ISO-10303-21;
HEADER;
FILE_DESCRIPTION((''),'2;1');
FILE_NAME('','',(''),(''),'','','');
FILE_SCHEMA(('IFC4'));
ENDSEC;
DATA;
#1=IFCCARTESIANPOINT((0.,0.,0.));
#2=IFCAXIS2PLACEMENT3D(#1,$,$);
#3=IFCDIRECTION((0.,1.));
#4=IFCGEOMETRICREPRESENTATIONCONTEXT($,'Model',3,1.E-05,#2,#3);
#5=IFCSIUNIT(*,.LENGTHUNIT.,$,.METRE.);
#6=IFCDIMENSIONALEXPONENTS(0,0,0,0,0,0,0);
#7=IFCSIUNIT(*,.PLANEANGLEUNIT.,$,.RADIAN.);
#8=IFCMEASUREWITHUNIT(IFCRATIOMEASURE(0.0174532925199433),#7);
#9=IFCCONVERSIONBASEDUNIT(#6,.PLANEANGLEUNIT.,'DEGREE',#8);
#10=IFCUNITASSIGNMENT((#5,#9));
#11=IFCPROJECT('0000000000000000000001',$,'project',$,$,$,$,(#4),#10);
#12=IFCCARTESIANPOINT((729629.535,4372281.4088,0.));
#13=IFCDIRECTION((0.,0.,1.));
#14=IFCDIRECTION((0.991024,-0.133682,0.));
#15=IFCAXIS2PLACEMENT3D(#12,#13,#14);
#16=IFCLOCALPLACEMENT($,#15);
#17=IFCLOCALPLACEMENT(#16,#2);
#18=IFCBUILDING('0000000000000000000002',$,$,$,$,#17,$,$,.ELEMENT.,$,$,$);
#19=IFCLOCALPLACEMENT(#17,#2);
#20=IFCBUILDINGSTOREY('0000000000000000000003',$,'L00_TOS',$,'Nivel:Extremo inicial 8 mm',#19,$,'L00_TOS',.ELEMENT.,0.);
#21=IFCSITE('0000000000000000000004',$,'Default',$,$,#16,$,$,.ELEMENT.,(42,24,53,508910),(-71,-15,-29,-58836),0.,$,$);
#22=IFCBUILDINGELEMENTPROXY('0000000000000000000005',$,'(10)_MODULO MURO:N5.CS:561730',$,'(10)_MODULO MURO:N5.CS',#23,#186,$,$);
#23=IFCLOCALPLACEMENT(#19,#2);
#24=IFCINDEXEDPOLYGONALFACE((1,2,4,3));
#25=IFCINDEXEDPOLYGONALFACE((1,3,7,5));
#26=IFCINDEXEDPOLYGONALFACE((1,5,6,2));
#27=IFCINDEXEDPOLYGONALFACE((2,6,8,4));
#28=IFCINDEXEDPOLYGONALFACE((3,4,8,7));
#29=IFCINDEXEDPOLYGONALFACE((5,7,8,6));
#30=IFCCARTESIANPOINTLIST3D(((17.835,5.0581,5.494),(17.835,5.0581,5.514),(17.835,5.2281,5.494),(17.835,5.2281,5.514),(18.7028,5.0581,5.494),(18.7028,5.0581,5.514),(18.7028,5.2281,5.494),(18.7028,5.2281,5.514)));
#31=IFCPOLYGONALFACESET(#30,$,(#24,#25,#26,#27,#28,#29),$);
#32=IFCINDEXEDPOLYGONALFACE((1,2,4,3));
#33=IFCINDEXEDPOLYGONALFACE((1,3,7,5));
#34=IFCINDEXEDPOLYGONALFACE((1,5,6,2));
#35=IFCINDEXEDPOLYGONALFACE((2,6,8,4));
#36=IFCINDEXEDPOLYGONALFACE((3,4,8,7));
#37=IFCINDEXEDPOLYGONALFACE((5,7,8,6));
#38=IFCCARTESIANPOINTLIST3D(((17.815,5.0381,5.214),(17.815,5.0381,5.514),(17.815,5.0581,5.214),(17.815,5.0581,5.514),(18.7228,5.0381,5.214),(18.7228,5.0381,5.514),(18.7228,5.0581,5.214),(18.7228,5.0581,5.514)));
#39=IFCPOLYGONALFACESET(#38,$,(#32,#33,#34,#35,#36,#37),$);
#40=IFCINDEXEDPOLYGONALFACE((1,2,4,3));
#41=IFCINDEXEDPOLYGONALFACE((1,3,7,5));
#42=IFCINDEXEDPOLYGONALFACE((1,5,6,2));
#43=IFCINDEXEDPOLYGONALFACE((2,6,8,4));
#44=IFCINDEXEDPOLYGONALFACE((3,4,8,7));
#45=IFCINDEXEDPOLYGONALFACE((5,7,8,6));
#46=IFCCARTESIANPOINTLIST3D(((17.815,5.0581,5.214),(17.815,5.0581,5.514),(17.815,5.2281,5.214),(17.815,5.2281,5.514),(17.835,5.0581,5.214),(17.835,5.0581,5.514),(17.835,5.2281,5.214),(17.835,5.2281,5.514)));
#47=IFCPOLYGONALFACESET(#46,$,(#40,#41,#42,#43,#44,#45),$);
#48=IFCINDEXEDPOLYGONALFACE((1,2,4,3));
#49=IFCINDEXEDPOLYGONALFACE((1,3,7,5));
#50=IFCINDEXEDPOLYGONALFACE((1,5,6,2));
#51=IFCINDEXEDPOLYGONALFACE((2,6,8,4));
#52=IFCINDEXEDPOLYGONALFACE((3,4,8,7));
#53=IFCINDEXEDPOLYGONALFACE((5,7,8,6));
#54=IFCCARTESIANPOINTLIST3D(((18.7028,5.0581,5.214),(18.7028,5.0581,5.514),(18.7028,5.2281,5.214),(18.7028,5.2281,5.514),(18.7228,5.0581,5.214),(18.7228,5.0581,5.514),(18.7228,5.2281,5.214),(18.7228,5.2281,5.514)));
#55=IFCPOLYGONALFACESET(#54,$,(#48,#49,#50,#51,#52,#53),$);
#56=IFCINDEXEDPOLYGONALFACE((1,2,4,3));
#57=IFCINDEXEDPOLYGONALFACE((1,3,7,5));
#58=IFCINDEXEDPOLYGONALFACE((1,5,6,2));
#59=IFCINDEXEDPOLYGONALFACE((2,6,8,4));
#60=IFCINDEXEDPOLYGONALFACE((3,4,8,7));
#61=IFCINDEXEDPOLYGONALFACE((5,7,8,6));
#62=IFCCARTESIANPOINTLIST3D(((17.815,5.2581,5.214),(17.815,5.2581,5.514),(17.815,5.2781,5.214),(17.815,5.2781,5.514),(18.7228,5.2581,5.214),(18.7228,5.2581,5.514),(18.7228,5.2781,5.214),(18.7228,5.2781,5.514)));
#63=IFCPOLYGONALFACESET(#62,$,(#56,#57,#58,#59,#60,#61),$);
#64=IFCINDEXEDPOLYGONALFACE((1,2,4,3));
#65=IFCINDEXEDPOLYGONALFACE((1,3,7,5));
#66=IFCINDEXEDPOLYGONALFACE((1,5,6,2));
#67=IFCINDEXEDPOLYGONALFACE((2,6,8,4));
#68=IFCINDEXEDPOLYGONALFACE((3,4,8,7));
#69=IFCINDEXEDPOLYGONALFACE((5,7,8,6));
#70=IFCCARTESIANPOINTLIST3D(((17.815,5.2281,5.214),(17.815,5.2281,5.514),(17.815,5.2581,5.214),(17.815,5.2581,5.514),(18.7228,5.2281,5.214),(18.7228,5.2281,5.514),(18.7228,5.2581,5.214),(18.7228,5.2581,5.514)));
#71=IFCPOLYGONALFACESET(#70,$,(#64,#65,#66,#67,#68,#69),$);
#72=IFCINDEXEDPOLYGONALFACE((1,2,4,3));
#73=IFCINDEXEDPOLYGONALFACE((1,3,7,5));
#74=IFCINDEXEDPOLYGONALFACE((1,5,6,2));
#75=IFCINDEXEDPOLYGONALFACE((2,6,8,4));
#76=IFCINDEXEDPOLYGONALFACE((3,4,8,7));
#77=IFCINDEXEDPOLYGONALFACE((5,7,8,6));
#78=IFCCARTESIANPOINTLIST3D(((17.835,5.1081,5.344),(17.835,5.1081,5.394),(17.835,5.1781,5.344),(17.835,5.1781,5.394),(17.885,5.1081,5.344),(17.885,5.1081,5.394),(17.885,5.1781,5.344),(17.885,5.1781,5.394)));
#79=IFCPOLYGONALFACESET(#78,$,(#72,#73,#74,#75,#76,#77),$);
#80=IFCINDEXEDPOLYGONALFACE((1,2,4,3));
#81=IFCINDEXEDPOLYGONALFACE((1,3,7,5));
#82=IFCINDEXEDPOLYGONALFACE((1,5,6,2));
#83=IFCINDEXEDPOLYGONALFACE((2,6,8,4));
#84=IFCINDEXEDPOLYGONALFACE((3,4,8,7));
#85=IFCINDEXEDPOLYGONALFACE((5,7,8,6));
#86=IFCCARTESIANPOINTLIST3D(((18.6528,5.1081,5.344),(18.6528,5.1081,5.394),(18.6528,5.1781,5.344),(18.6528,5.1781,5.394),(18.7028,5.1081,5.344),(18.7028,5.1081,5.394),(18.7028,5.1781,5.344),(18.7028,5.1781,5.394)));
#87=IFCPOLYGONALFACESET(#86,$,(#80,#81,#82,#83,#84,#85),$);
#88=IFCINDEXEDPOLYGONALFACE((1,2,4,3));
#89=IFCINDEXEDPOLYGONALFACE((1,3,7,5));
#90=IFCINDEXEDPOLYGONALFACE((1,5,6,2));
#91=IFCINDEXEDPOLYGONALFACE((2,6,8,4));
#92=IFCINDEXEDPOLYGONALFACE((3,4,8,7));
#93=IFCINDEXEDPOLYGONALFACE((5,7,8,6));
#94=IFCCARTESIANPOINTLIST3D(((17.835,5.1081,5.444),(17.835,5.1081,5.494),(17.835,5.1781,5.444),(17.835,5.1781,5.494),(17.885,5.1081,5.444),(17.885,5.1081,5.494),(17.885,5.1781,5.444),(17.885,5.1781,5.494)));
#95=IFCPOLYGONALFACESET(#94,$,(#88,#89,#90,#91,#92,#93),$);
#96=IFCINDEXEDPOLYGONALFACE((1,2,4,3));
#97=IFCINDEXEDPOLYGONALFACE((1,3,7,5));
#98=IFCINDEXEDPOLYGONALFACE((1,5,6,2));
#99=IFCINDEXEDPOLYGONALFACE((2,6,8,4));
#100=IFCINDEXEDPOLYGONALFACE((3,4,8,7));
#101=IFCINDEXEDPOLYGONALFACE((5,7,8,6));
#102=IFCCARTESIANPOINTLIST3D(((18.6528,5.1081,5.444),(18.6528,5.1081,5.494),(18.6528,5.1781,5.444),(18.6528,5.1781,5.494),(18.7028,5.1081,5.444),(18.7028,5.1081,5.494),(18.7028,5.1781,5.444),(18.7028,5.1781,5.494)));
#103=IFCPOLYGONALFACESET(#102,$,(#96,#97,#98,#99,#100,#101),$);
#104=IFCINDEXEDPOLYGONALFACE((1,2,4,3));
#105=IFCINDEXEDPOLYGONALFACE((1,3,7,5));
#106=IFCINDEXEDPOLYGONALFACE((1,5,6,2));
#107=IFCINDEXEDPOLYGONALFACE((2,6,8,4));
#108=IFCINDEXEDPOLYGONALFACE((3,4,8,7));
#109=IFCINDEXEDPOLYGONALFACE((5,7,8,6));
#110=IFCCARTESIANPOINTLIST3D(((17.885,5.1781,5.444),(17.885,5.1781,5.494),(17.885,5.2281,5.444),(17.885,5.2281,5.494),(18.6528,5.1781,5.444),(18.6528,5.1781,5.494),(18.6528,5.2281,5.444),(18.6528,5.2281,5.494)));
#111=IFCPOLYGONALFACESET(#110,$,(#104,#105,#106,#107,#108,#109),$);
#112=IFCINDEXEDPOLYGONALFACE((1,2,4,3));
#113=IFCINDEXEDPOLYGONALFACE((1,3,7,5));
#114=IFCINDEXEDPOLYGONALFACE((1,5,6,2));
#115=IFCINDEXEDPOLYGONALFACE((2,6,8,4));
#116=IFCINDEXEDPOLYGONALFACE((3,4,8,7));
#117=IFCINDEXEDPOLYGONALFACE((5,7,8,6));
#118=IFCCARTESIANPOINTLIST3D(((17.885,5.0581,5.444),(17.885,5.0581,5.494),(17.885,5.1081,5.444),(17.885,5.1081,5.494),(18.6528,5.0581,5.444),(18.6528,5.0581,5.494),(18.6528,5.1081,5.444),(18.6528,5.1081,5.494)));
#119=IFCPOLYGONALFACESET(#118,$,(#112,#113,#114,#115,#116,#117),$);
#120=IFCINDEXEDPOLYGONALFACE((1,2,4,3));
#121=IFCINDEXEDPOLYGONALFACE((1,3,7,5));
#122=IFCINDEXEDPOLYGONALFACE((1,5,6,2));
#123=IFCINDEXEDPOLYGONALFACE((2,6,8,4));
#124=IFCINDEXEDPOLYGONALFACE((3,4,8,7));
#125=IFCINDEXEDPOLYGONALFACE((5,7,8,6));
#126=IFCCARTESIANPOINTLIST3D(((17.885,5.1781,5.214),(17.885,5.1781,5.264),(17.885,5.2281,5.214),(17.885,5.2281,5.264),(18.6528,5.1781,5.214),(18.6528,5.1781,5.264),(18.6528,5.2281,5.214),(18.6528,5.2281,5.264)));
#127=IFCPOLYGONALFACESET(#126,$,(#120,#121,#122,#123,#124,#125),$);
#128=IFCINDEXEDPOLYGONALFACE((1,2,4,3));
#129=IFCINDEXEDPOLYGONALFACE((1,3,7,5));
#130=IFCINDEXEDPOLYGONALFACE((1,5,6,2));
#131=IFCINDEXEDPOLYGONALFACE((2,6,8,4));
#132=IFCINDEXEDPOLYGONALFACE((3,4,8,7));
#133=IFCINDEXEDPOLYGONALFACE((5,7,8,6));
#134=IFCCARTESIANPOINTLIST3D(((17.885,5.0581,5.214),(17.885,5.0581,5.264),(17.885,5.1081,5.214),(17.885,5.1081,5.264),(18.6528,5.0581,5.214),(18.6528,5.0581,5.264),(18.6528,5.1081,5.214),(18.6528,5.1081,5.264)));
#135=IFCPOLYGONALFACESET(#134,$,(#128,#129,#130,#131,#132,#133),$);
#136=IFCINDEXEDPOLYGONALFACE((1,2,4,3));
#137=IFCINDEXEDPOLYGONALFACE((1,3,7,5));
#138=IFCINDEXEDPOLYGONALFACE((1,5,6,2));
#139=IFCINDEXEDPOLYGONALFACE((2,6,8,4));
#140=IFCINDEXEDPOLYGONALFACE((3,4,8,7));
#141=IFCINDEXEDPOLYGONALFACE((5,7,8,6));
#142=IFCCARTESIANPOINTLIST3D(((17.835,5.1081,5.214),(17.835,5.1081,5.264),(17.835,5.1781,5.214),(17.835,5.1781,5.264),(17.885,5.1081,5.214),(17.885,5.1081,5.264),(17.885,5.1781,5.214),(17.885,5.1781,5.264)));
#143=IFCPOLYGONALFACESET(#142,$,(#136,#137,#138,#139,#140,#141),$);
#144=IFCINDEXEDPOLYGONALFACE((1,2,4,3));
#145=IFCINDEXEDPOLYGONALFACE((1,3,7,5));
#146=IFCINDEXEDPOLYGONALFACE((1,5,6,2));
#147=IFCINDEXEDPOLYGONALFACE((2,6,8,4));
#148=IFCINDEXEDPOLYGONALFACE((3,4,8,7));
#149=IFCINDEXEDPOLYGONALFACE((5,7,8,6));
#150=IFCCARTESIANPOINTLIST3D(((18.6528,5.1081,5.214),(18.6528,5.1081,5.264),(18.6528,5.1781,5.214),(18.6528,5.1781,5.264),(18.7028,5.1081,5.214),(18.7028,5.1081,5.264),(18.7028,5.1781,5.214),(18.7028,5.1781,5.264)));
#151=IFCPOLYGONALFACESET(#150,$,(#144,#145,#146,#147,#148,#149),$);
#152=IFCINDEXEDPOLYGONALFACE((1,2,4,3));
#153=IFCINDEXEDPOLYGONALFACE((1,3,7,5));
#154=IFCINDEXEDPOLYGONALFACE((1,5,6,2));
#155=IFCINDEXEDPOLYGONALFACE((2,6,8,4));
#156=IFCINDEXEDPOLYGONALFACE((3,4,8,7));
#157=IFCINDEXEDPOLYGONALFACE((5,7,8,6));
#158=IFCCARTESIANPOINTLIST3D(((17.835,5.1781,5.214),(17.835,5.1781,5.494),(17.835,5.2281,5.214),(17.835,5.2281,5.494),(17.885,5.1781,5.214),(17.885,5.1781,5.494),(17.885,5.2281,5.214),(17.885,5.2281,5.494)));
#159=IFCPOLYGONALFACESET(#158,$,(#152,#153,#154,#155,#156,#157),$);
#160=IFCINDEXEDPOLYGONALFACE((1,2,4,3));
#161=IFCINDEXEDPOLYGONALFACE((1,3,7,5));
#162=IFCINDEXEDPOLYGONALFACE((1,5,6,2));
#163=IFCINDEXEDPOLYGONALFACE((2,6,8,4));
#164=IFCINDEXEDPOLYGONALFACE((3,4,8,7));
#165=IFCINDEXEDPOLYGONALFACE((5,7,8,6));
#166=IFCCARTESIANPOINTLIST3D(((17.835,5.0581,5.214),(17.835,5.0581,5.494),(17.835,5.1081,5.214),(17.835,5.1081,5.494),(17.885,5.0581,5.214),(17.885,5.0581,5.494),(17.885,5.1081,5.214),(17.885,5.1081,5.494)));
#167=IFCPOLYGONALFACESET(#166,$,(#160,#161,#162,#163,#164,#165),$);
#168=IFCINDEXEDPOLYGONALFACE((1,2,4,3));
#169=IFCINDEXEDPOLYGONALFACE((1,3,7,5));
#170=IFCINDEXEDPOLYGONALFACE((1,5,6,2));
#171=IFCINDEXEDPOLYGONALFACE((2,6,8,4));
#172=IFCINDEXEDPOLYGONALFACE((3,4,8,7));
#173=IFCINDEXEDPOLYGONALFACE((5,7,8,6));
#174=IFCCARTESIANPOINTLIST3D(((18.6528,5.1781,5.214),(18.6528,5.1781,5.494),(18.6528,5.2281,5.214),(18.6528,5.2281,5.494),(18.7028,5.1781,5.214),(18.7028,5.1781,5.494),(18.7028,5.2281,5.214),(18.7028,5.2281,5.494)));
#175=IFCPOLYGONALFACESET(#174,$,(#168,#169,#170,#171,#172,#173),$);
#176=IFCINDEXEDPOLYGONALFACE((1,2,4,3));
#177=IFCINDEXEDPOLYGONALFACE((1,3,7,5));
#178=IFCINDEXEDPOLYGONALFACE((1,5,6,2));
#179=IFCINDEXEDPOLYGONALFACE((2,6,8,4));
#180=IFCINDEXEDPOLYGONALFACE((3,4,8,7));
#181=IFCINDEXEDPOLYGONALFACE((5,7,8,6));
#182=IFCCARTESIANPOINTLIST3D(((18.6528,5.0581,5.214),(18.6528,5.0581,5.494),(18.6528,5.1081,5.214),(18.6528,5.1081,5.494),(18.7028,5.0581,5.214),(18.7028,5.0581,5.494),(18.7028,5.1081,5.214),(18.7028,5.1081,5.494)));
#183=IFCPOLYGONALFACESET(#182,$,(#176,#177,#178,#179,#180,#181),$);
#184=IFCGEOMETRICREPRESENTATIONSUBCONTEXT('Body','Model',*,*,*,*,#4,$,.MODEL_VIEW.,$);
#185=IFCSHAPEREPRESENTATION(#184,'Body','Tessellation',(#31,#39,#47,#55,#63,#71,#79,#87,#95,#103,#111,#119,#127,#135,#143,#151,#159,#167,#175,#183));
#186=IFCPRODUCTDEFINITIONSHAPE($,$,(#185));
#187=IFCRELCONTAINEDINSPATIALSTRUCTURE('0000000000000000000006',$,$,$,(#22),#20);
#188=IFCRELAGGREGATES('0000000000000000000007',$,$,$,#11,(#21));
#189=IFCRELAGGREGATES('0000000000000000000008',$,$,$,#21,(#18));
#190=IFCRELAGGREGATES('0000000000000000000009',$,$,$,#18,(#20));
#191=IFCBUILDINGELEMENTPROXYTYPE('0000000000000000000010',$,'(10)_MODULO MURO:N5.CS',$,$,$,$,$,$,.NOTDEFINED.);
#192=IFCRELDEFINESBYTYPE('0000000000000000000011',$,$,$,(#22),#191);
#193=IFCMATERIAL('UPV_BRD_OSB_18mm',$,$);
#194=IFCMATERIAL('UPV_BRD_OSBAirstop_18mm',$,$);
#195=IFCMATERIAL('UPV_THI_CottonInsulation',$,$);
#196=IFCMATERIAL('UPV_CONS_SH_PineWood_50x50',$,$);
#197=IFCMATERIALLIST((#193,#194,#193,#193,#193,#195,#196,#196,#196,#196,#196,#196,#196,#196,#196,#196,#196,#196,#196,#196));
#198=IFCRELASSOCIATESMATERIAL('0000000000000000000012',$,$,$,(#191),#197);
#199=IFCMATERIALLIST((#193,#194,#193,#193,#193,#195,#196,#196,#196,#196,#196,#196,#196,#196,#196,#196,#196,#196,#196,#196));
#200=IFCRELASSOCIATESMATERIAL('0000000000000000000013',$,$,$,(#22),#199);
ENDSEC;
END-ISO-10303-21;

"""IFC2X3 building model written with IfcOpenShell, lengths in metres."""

from ifc_helpers import new_model, entity, si_unit, converted_unit, direction, frame, frame_2d, origin, origin_2d_with_axis, place, context, subcontext, project, spatial, rectangle, extrude, source, transform, mapped, material, material_list, type_object, type_shapes, element, save


model = new_model("IFC2X3")

# Units and contexts
model_context = context("Model", 3, precision=1e-05, world=origin(), true_north=direction((0.0, 1.0)))
body_context = subcontext(model_context, "Body", "Model", "MODEL_VIEW")
ifc_project = project(units=[si_unit("LENGTHUNIT", "METRE"), converted_unit("PLANEANGLEUNIT", "DEGREE", entity("IfcRatioMeasure", 0.0174532925199433), si_unit("PLANEANGLEUNIT", "RADIAN"), dimensions=[0, 0, 0, 0, 0, 0, 0])], contexts=[model_context])

# Site, building, storey
site_placement = place(None, frame((729629.535, 4372281.4088, 0.0), z_axis=(0.0, 0.0, 1.0), x_axis=(0.991024, -0.133682, 0.0)))
site = spatial("IfcSite", under=ifc_project, at=site_placement, Name="Default", CompositionType="ELEMENT", RefLatitude=(42, 24, 53, 508910), RefLongitude=(-71, -15, -29, -58836), RefElevation=0.0)
building_placement = place(site_placement, origin())
building = spatial("IfcBuilding", under=site, at=building_placement, CompositionType="ELEMENT")
storey_placement = place(building_placement, origin())
storey = spatial("IfcBuildingStorey", under=building, at=storey_placement, Name="L00_TOS", ObjectType="Nivel:Extremo inicial 8 mm", LongName="L00_TOS", CompositionType="ELEMENT", Elevation=0.0)

# Building element proxy
ifc_material_1 = material(Name="UPV_BRD_OSBAirstop_18mm")
ifc_material_2 = material(Name="UPV_BRD_OSB_18mm")
ifc_material_3 = material(Name="UPV_THI_CottonInsulation")
ifc_material_4 = material(Name="UPV_CONS_SH_PineWood_50x50")
ifc_material_list_1 = material_list([ifc_material_2, ifc_material_1, ifc_material_2, ifc_material_2, ifc_material_2, ifc_material_3, ifc_material_4, ifc_material_4, ifc_material_4, ifc_material_4, ifc_material_4, ifc_material_4, ifc_material_4, ifc_material_4, ifc_material_4, ifc_material_4, ifc_material_4, ifc_material_4, ifc_material_4, ifc_material_4])
ifc_material_list_2 = material_list([ifc_material_2, ifc_material_1, ifc_material_2, ifc_material_2, ifc_material_2, ifc_material_3, ifc_material_4, ifc_material_4, ifc_material_4, ifc_material_4, ifc_material_4, ifc_material_4, ifc_material_4, ifc_material_4, ifc_material_4, ifc_material_4, ifc_material_4, ifc_material_4, ifc_material_4, ifc_material_4])
building_element_proxy_type_1 = type_object("IfcBuildingElementProxyType", Name="(10)_MODULO MURO:N5.CS", PredefinedType="NOTDEFINED", material=ifc_material_list_2)
shared_shape_1 = source(origin(), body_context, "Body", "SweptSolid", [
    extrude(rectangle(XDim=0.8678, YDim=0.17, at=origin_2d_with_axis()), frame((0.0, 0.0, 0.28), z_axis=(0.0, 0.0, 1.0), x_axis=(-1.0, 0.0, 0.0)), (0.0, 0.0, 1.0), 0.02),
    extrude(rectangle(XDim=0.9078, YDim=0.02, at=origin_2d_with_axis()), frame((0.0, -0.095, 0.0)), (0.0, 0.0, 1.0), 0.3),
    extrude(rectangle(XDim=0.17, YDim=0.02, at=frame_2d((0.0, 0.0), x_axis=(1.0, 0.0))), frame((-0.4439, 0.0, 0.0), z_axis=(0.0, 0.0, 1.0), x_axis=(0.0, -1.0, 0.0)), (0.0, 0.0, 1.0), 0.3),
    extrude(rectangle(XDim=0.17, YDim=0.02, at=origin_2d_with_axis()), frame((0.4439, 0.0, 0.0), z_axis=(0.0, 0.0, 1.0), x_axis=(0.0, -1.0, 0.0)), (0.0, 0.0, 1.0), 0.3),
    extrude(rectangle(XDim=0.9078, YDim=0.02, at=origin_2d_with_axis()), frame((0.0, 0.125, 0.0), z_axis=(0.0, 0.0, 1.0), x_axis=(-1.0, 0.0, 0.0)), (0.0, 0.0, 1.0), 0.3),
    extrude(rectangle(XDim=0.9078, YDim=0.03, at=frame_2d((0.0, 0.0), x_axis=(1.0, 0.0))), frame((0.0, 0.1, 0.0), z_axis=(0.0, 0.0, 1.0), x_axis=(-1.0, 0.0, 0.0)), (0.0, 0.0, 1.0), 0.3),
    extrude(rectangle(XDim=0.07, YDim=0.05, at=origin_2d_with_axis()), frame((-0.4089, 0.0, 0.13), z_axis=(0.0, 0.0, 1.0), x_axis=(0.0, 1.0, 0.0)), (0.0, 0.0, 1.0), 0.05),
    extrude(rectangle(XDim=0.07, YDim=0.05, at=origin_2d_with_axis()), frame((0.4089, 0.0, 0.13), z_axis=(0.0, 0.0, 1.0), x_axis=(0.0, 1.0, 0.0)), (0.0, 0.0, 1.0), 0.05),
    extrude(rectangle(XDim=0.07, YDim=0.05, at=origin_2d_with_axis()), frame((-0.4089, 0.0, 0.23), z_axis=(0.0, 0.0, 1.0), x_axis=(0.0, -1.0, 0.0)), (0.0, 0.0, 1.0), 0.05),
    extrude(rectangle(XDim=0.07, YDim=0.05, at=frame_2d((0.0, 0.0), x_axis=(1.0, 0.0))), frame((0.4089, 0.0, 0.23), z_axis=(0.0, 0.0, 1.0), x_axis=(0.0, -1.0, 0.0)), (0.0, 0.0, 1.0), 0.05),
    extrude(rectangle(XDim=0.7678, YDim=0.05, at=origin_2d_with_axis()), frame((0.0, 0.06, 0.23), z_axis=(0.0, 0.0, 1.0), x_axis=(-1.0, 0.0, 0.0)), (0.0, 0.0, 1.0), 0.05),
    extrude(rectangle(XDim=0.05, YDim=0.7678, at=frame_2d((0.0, 0.0), x_axis=(1.0, 0.0))), frame((0.0, -0.06, 0.23), z_axis=(0.0, 0.0, 1.0), x_axis=(0.0, -1.0, 0.0)), (0.0, 0.0, 1.0), 0.05),
    extrude(rectangle(XDim=0.05, YDim=0.7678, at=origin_2d_with_axis()), frame((0.0, 0.06, 0.0), z_axis=(0.0, 0.0, 1.0), x_axis=(0.0, -1.0, 0.0)), (0.0, 0.0, 1.0), 0.05),
    extrude(rectangle(XDim=0.05, YDim=0.7678, at=frame_2d((0.0, 0.0), x_axis=(1.0, 0.0))), frame((0.0, -0.06, 0.0), z_axis=(0.0, 0.0, 1.0), x_axis=(0.0, -1.0, 0.0)), (0.0, 0.0, 1.0), 0.05),
    extrude(rectangle(XDim=0.07, YDim=0.05, at=origin_2d_with_axis()), frame((-0.4089, 0.0, 0.0), z_axis=(0.0, 0.0, 1.0), x_axis=(0.0, -1.0, 0.0)), (0.0, 0.0, 1.0), 0.05),
    extrude(rectangle(XDim=0.05, YDim=0.07, at=origin_2d_with_axis()), frame((0.4089, 0.0, 0.0), z_axis=(0.0, 0.0, 1.0), x_axis=(-1.0, 0.0, 0.0)), (0.0, 0.0, 1.0), 0.05),
    extrude(rectangle(XDim=0.05, YDim=0.05, at=origin_2d_with_axis()), frame((-0.4089, 0.06, 0.0), z_axis=(0.0, 0.0, 1.0), x_axis=(0.0, -1.0, 0.0)), (0.0, 0.0, 1.0), 0.28),
    extrude(rectangle(XDim=0.05, YDim=0.05, at=frame_2d((0.0, 0.0), x_axis=(1.0, 0.0))), frame((-0.4089, -0.06, 0.0), z_axis=(0.0, 0.0, 1.0), x_axis=(0.0, -1.0, 0.0)), (0.0, 0.0, 1.0), 0.28),
    extrude(rectangle(XDim=0.05, YDim=0.05, at=origin_2d_with_axis()), frame((0.4089, 0.06, 0.0), z_axis=(0.0, 0.0, 1.0), x_axis=(0.0, -1.0, 0.0)), (0.0, 0.0, 1.0), 0.28),
    extrude(rectangle(XDim=0.05, YDim=0.05, at=frame_2d((0.0, 0.0), x_axis=(1.0, 0.0))), frame((0.4089, -0.06, 0.0), z_axis=(0.0, 0.0, 1.0), x_axis=(0.0, -1.0, 0.0)), (0.0, 0.0, 1.0), 0.28),
])
type_shapes(building_element_proxy_type_1, [shared_shape_1])
proxy_1_placement = place(storey_placement, frame((18.2689, 5.1431, 5.214)))
element("IfcBuildingElementProxy", 1, at=proxy_1_placement, inside=storey, type_object=building_element_proxy_type_1, material=ifc_material_list_1, Name="(10)_MODULO MURO:N5.CS:561730", ObjectType="(10)_MODULO MURO:N5.CS", context=body_context, shape_type="MappedRepresentation", body=[
    mapped(shared_shape_1, transform((0.0, 0.0, 0.0), scale=1.0)),
])

save(model, "model.ifc")
